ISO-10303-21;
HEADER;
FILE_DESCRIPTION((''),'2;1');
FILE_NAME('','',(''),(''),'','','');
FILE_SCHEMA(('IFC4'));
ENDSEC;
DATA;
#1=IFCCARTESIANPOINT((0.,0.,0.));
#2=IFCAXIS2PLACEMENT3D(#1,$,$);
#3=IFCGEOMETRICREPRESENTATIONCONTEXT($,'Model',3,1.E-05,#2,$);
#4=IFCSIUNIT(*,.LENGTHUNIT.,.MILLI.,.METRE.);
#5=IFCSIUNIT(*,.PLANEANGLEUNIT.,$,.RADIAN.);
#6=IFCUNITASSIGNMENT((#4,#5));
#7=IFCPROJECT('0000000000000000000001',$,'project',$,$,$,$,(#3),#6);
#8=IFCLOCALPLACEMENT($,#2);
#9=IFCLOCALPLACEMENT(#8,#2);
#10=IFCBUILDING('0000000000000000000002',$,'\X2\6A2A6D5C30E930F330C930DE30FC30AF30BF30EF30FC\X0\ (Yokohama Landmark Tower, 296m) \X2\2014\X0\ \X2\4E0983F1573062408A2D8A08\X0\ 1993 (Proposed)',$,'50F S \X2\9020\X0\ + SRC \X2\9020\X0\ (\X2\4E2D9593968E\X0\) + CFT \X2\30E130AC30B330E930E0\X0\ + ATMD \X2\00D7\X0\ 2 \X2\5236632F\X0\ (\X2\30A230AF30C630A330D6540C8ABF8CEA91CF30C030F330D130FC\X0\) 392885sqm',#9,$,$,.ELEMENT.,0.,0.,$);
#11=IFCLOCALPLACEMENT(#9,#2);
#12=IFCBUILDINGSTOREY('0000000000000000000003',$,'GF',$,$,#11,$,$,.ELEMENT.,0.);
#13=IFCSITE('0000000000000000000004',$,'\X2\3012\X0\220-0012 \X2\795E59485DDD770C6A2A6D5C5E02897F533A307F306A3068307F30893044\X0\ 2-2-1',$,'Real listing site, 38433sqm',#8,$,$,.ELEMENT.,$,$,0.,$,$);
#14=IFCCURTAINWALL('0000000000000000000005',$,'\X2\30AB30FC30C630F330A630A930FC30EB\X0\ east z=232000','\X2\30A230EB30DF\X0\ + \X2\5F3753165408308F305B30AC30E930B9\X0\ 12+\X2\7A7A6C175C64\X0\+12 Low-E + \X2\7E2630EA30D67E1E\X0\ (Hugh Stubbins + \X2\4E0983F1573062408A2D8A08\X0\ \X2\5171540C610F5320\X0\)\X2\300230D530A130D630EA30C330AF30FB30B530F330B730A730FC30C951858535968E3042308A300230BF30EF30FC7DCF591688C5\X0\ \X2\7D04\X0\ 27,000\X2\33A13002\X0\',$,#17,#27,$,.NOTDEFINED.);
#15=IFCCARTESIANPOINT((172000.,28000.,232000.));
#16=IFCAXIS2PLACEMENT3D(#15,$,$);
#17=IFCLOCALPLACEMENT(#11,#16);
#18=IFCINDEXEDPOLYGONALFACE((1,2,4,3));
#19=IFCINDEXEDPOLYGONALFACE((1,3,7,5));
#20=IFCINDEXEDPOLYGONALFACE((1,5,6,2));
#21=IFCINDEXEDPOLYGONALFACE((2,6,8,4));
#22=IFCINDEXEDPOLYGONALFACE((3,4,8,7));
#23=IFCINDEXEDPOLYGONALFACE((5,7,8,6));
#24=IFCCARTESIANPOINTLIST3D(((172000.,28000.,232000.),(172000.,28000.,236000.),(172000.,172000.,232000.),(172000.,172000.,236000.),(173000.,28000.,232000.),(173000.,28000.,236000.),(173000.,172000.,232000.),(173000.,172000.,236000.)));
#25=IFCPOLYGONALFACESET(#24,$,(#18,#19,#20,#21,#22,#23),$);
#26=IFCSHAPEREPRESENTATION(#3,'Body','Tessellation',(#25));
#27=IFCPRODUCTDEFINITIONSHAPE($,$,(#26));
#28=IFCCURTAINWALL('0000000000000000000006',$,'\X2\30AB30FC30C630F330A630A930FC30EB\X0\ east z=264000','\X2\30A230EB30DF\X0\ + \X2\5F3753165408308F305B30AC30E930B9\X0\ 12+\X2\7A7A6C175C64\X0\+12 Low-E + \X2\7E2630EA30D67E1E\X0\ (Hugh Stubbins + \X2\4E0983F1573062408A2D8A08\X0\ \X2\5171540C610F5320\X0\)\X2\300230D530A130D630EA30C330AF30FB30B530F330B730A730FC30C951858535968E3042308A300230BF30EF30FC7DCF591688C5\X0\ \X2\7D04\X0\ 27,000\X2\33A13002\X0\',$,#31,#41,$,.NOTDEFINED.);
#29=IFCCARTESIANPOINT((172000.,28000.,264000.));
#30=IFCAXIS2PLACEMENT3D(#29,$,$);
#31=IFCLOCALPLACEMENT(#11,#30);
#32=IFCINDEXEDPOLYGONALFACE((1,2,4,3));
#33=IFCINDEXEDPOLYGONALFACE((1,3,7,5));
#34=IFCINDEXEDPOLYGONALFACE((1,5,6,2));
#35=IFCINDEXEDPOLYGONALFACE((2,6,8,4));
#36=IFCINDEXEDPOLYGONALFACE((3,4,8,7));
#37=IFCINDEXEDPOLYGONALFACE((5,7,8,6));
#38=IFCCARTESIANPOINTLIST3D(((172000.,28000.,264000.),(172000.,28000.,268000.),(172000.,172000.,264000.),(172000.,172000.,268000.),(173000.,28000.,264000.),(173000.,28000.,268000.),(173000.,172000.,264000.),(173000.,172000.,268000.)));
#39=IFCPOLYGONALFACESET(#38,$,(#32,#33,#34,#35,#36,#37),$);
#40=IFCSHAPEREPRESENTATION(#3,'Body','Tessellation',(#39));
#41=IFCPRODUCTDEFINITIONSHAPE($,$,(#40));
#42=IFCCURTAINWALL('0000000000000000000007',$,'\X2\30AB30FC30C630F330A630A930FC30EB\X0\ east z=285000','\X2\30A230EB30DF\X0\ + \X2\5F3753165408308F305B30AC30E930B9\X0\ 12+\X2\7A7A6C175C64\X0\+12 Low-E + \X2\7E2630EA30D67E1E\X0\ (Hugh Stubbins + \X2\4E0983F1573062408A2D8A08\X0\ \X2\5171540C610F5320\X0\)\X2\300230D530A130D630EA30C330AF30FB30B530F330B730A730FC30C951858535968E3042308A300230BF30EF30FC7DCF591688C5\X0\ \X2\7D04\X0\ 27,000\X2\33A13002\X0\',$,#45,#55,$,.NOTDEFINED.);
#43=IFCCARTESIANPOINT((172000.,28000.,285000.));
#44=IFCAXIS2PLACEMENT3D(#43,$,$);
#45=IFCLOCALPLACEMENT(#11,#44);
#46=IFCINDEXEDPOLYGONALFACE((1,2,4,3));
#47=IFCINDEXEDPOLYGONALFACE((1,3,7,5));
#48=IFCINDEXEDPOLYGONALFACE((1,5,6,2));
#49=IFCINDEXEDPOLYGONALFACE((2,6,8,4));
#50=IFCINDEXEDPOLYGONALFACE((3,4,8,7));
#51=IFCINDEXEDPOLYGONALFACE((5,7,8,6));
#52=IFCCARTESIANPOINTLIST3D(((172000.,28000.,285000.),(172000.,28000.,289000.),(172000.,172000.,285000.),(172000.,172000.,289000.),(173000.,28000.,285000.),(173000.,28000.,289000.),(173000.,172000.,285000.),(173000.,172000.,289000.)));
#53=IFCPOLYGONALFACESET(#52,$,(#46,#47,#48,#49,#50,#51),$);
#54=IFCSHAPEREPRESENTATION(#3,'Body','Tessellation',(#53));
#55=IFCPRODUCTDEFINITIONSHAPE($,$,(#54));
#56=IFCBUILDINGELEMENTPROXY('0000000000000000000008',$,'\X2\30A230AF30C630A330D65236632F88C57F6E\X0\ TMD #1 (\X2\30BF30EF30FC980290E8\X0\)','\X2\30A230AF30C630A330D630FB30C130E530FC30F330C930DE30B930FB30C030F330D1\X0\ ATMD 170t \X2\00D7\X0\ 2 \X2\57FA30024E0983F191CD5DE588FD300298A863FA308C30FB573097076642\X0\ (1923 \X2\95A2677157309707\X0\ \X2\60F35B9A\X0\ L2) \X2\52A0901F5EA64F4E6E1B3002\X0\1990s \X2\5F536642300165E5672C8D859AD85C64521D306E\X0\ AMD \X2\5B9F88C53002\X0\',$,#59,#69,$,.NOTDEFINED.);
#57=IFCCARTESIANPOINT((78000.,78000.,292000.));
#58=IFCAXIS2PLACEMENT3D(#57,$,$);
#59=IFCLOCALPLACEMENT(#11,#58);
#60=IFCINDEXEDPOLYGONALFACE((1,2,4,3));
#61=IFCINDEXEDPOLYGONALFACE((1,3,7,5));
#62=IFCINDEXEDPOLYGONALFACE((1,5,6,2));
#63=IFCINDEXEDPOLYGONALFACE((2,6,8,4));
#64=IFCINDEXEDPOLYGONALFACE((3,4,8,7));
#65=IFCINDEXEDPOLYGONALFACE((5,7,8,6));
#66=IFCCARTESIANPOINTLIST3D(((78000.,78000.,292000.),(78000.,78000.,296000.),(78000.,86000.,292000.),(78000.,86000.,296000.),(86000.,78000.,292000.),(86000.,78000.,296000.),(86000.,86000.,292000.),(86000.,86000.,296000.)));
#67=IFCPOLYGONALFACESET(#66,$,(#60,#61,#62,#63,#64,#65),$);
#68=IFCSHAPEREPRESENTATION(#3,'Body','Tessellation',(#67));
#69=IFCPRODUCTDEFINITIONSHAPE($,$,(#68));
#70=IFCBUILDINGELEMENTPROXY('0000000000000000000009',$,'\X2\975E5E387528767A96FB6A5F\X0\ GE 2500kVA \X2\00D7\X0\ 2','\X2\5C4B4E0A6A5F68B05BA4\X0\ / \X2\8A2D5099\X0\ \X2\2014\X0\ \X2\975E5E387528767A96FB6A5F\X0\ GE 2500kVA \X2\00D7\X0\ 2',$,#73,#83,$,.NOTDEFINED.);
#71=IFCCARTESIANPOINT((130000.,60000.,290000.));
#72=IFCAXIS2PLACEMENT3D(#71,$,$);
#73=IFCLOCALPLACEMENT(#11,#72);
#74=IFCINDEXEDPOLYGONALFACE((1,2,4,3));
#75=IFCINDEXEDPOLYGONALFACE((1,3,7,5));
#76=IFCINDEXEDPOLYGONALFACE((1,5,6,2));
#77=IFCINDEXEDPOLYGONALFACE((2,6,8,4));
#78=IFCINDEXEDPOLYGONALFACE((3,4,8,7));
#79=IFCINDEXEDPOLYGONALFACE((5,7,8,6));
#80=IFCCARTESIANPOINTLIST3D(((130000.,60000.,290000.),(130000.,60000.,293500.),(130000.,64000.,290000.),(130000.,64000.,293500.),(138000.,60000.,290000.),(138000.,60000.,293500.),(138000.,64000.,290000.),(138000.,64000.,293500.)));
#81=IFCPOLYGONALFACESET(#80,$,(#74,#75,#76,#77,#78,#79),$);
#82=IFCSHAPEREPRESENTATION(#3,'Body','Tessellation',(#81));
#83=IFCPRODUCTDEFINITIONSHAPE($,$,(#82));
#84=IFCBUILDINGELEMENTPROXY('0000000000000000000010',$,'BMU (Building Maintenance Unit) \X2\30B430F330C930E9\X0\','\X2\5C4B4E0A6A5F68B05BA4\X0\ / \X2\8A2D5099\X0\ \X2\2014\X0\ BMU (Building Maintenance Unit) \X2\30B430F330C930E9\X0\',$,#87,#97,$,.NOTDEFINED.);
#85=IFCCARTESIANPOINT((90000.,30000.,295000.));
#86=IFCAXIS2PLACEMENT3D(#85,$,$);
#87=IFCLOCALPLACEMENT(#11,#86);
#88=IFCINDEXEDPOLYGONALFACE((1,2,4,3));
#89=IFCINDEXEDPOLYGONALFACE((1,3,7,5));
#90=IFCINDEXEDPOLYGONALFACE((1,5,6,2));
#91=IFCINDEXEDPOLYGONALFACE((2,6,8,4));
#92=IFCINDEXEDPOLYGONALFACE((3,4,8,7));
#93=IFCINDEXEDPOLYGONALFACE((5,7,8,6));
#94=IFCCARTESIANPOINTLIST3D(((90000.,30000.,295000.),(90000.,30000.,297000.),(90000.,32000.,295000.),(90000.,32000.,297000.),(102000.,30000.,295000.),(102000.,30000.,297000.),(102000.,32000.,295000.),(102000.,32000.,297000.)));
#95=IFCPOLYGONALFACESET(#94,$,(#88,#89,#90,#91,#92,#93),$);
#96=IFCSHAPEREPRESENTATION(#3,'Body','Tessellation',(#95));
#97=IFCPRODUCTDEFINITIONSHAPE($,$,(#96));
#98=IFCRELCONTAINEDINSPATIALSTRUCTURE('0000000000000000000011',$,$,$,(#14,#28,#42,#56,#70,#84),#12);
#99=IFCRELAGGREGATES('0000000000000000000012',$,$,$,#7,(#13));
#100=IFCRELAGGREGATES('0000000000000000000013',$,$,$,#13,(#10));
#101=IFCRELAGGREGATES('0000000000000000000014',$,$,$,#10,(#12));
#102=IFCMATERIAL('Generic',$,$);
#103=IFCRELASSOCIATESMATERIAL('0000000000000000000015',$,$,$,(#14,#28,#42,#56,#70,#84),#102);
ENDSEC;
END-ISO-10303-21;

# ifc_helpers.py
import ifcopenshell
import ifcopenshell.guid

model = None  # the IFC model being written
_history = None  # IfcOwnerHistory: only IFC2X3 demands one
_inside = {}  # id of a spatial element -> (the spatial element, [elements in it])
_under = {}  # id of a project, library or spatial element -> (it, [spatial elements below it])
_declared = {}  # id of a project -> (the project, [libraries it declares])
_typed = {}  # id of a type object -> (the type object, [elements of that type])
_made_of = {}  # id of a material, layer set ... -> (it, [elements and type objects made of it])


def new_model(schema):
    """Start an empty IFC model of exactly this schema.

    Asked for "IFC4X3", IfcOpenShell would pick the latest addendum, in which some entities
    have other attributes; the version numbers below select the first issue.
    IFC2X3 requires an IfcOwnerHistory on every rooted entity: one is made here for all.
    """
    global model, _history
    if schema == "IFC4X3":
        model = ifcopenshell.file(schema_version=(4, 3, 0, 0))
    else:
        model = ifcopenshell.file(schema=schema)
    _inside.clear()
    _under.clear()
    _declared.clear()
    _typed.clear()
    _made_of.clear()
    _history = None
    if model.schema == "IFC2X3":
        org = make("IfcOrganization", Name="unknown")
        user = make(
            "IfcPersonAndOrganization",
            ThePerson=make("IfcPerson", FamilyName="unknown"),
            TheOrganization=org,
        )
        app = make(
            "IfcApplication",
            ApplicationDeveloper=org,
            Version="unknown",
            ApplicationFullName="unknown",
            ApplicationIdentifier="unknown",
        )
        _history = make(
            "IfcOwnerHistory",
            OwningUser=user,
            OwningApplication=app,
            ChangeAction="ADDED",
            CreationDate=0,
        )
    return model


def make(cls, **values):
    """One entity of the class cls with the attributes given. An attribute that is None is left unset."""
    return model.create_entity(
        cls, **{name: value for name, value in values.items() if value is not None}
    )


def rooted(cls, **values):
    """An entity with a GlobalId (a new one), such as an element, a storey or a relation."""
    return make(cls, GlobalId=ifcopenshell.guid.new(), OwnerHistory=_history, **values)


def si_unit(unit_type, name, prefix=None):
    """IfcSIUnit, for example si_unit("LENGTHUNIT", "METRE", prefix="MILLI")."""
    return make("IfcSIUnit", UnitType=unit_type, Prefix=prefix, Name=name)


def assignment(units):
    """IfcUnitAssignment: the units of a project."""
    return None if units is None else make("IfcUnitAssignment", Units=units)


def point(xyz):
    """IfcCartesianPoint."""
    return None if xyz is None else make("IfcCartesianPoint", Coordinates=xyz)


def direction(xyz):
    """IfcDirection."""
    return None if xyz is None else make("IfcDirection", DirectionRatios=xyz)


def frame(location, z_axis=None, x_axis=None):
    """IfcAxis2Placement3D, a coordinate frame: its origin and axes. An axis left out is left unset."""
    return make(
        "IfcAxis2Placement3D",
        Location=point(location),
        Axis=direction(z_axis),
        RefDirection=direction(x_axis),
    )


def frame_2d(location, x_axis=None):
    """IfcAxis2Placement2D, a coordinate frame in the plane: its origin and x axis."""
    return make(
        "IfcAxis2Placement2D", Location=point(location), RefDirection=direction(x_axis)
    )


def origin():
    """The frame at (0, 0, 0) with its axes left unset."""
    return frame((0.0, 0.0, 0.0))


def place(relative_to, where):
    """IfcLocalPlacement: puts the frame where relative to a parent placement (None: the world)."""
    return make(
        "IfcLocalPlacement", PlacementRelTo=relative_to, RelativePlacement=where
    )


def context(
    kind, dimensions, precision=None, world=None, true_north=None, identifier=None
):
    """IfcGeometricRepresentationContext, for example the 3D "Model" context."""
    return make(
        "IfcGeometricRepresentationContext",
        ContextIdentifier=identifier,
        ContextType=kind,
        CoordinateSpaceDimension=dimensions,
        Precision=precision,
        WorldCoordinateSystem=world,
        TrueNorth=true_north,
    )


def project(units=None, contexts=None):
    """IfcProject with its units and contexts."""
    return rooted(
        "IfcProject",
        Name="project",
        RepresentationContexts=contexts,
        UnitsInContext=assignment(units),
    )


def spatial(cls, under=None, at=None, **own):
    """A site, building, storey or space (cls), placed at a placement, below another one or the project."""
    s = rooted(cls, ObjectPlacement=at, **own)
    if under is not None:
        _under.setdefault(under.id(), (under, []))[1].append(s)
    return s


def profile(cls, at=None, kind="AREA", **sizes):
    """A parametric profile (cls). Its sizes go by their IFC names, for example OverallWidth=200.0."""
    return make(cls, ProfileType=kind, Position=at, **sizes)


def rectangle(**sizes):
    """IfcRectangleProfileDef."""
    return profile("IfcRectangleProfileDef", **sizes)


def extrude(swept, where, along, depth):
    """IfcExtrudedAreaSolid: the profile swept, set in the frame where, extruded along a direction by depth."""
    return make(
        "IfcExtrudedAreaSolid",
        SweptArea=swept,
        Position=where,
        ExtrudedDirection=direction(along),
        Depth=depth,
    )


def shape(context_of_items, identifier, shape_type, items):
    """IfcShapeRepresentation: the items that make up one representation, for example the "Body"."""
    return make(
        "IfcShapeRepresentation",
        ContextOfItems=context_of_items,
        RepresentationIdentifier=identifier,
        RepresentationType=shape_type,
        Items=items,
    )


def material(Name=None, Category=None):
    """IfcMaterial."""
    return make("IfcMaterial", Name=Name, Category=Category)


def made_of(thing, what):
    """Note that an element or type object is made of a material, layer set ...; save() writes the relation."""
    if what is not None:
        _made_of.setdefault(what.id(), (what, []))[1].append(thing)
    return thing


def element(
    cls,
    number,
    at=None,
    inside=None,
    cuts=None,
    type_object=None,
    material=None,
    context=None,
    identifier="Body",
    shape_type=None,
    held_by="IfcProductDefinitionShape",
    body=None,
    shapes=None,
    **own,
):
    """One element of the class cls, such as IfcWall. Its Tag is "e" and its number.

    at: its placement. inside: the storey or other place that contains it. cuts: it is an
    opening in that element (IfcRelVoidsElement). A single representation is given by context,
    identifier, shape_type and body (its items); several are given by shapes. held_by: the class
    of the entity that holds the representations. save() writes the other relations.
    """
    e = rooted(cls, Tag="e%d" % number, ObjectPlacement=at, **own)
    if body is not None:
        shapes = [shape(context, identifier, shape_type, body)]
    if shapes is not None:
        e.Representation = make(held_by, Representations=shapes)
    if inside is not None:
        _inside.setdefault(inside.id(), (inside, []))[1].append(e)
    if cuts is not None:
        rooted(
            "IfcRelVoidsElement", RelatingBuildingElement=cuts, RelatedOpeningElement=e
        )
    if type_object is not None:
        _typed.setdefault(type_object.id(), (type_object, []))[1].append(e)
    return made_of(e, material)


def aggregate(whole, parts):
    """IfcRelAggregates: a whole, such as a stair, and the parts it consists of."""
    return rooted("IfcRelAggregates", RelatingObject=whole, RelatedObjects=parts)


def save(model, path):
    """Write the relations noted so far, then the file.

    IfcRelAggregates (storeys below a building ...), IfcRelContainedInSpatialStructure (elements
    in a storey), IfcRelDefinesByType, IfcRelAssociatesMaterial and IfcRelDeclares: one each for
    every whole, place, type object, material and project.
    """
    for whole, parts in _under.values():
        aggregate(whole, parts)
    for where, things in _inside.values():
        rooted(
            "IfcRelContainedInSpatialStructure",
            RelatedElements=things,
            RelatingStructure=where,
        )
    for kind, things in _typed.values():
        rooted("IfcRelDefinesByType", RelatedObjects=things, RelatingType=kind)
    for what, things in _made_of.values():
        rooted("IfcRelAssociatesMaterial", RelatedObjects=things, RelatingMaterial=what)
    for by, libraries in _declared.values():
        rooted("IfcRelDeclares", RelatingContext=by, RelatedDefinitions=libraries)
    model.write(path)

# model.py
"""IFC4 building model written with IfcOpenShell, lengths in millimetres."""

from ifc_helpers import new_model, si_unit, frame, frame_2d, origin, place, context, project, spatial, rectangle, extrude, material, element, save


model = new_model("IFC4")

# Units and contexts
model_context = context("Model", 3, precision=1e-05, world=origin())
ifc_project = project(units=[si_unit("LENGTHUNIT", "METRE", prefix="MILLI"), si_unit("PLANEANGLEUNIT", "RADIAN")], contexts=[model_context])

# Site, building, storey
site_placement = place(None, origin())
site = spatial("IfcSite", under=ifc_project, at=site_placement, Name="〒220-0012 神奈川県横浜市西区みなとみらい 2-2-1", ObjectType="Real listing site, 38433sqm", CompositionType="ELEMENT", RefElevation=0.0)
building_placement = place(site_placement, origin())
building = spatial("IfcBuilding", under=site, at=building_placement, Name="横浜ランドマークタワー (Yokohama Landmark Tower, 296m) — 三菱地所設計 1993 (Proposed)", ObjectType="50F S 造 + SRC 造 (中間階) + CFT メガコラム + ATMD × 2 制振 (アクティブ同調質量ダンパー) 392885sqm", CompositionType="ELEMENT", ElevationOfRefHeight=0.0, ElevationOfTerrain=0.0)
storey_placement = place(building_placement, origin())
storey = spatial("IfcBuildingStorey", under=building, at=storey_placement, Name="GF", CompositionType="ELEMENT", Elevation=0.0)

# Shared definitions
ifc_material_1 = material(Name="Generic")

# Curtain walls
curtain_wall_1_placement = place(storey_placement, frame((172000.0, 28000.0, 232000.0)))
element("IfcCurtainWall", 1, at=curtain_wall_1_placement, inside=storey, material=ifc_material_1, Name="カーテンウォール east z=232000", Description="アルミ + 強化合わせガラス 12+空気層+12 Low-E + 縦リブ縞 (Hugh Stubbins + 三菱地所設計 共同意匠)。ファブリック・サンシェード内蔵階あり。タワー総外装 約 27,000㎡。", PredefinedType="NOTDEFINED", context=model_context, shape_type="SweptSolid", body=[
    extrude(rectangle(XDim=1000.0, YDim=144000.0, at=frame_2d((500.0, 72000.0))), frame((172000.0, 28000.0, 232000.0)), (0.0, 0.0, 1.0), 4000.0),
])
curtain_wall_2_placement = place(storey_placement, frame((172000.0, 28000.0, 264000.0)))
element("IfcCurtainWall", 2, at=curtain_wall_2_placement, inside=storey, material=ifc_material_1, Name="カーテンウォール east z=264000", Description="アルミ + 強化合わせガラス 12+空気層+12 Low-E + 縦リブ縞 (Hugh Stubbins + 三菱地所設計 共同意匠)。ファブリック・サンシェード内蔵階あり。タワー総外装 約 27,000㎡。", PredefinedType="NOTDEFINED", context=model_context, shape_type="SweptSolid", body=[
    extrude(rectangle(XDim=1000.0, YDim=144000.0, at=frame_2d((500.0, 72000.0))), frame((172000.0, 28000.0, 264000.0)), (0.0, 0.0, 1.0), 4000.0),
])
curtain_wall_3_placement = place(storey_placement, frame((172000.0, 28000.0, 285000.0)))
element("IfcCurtainWall", 3, at=curtain_wall_3_placement, inside=storey, material=ifc_material_1, Name="カーテンウォール east z=285000", Description="アルミ + 強化合わせガラス 12+空気層+12 Low-E + 縦リブ縞 (Hugh Stubbins + 三菱地所設計 共同意匠)。ファブリック・サンシェード内蔵階あり。タワー総外装 約 27,000㎡。", PredefinedType="NOTDEFINED", context=model_context, shape_type="SweptSolid", body=[
    extrude(rectangle(XDim=1000.0, YDim=144000.0, at=frame_2d((500.0, 72000.0))), frame((172000.0, 28000.0, 285000.0)), (0.0, 0.0, 1.0), 4000.0),
])

# Building element proxies
proxy_1_placement = place(storey_placement, frame((78000.0, 78000.0, 292000.0)))
element("IfcBuildingElementProxy", 4, at=proxy_1_placement, inside=storey, material=ifc_material_1, Name="アクティブ制振装置 TMD #1 (タワー頂部)", Description="アクティブ・チューンドマス・ダンパ ATMD 170t × 2 基。三菱重工製。風揺れ・地震時 (1923 関東地震 想定 L2) 加速度低減。1990s 当時、日本超高層初の AMD 実装。", PredefinedType="NOTDEFINED", context=model_context, shape_type="SweptSolid", body=[
    extrude(rectangle(XDim=8000.0, YDim=8000.0, at=frame_2d((4000.0, 4000.0))), frame((78000.0, 78000.0, 292000.0)), (0.0, 0.0, 1.0), 4000.0),
])
proxy_2_placement = place(storey_placement, frame((130000.0, 60000.0, 290000.0)))
element("IfcBuildingElementProxy", 5, at=proxy_2_placement, inside=storey, material=ifc_material_1, Name="非常用発電機 GE 2500kVA × 2", Description="屋上機械室 / 設備 — 非常用発電機 GE 2500kVA × 2", PredefinedType="NOTDEFINED", context=model_context, shape_type="SweptSolid", body=[
    extrude(rectangle(XDim=8000.0, YDim=4000.0, at=frame_2d((4000.0, 2000.0))), frame((130000.0, 60000.0, 290000.0)), (0.0, 0.0, 1.0), 3500.0),
])
proxy_3_placement = place(storey_placement, frame((90000.0, 30000.0, 295000.0)))
element("IfcBuildingElementProxy", 6, at=proxy_3_placement, inside=storey, material=ifc_material_1, Name="BMU (Building Maintenance Unit) ゴンドラ", Description="屋上機械室 / 設備 — BMU (Building Maintenance Unit) ゴンドラ", PredefinedType="NOTDEFINED", context=model_context, shape_type="SweptSolid", body=[
    extrude(rectangle(XDim=12000.0, YDim=2000.0, at=frame_2d((6000.0, 1000.0))), frame((90000.0, 30000.0, 295000.0)), (0.0, 0.0, 1.0), 2000.0),
])

save(model, "model.ifc")
